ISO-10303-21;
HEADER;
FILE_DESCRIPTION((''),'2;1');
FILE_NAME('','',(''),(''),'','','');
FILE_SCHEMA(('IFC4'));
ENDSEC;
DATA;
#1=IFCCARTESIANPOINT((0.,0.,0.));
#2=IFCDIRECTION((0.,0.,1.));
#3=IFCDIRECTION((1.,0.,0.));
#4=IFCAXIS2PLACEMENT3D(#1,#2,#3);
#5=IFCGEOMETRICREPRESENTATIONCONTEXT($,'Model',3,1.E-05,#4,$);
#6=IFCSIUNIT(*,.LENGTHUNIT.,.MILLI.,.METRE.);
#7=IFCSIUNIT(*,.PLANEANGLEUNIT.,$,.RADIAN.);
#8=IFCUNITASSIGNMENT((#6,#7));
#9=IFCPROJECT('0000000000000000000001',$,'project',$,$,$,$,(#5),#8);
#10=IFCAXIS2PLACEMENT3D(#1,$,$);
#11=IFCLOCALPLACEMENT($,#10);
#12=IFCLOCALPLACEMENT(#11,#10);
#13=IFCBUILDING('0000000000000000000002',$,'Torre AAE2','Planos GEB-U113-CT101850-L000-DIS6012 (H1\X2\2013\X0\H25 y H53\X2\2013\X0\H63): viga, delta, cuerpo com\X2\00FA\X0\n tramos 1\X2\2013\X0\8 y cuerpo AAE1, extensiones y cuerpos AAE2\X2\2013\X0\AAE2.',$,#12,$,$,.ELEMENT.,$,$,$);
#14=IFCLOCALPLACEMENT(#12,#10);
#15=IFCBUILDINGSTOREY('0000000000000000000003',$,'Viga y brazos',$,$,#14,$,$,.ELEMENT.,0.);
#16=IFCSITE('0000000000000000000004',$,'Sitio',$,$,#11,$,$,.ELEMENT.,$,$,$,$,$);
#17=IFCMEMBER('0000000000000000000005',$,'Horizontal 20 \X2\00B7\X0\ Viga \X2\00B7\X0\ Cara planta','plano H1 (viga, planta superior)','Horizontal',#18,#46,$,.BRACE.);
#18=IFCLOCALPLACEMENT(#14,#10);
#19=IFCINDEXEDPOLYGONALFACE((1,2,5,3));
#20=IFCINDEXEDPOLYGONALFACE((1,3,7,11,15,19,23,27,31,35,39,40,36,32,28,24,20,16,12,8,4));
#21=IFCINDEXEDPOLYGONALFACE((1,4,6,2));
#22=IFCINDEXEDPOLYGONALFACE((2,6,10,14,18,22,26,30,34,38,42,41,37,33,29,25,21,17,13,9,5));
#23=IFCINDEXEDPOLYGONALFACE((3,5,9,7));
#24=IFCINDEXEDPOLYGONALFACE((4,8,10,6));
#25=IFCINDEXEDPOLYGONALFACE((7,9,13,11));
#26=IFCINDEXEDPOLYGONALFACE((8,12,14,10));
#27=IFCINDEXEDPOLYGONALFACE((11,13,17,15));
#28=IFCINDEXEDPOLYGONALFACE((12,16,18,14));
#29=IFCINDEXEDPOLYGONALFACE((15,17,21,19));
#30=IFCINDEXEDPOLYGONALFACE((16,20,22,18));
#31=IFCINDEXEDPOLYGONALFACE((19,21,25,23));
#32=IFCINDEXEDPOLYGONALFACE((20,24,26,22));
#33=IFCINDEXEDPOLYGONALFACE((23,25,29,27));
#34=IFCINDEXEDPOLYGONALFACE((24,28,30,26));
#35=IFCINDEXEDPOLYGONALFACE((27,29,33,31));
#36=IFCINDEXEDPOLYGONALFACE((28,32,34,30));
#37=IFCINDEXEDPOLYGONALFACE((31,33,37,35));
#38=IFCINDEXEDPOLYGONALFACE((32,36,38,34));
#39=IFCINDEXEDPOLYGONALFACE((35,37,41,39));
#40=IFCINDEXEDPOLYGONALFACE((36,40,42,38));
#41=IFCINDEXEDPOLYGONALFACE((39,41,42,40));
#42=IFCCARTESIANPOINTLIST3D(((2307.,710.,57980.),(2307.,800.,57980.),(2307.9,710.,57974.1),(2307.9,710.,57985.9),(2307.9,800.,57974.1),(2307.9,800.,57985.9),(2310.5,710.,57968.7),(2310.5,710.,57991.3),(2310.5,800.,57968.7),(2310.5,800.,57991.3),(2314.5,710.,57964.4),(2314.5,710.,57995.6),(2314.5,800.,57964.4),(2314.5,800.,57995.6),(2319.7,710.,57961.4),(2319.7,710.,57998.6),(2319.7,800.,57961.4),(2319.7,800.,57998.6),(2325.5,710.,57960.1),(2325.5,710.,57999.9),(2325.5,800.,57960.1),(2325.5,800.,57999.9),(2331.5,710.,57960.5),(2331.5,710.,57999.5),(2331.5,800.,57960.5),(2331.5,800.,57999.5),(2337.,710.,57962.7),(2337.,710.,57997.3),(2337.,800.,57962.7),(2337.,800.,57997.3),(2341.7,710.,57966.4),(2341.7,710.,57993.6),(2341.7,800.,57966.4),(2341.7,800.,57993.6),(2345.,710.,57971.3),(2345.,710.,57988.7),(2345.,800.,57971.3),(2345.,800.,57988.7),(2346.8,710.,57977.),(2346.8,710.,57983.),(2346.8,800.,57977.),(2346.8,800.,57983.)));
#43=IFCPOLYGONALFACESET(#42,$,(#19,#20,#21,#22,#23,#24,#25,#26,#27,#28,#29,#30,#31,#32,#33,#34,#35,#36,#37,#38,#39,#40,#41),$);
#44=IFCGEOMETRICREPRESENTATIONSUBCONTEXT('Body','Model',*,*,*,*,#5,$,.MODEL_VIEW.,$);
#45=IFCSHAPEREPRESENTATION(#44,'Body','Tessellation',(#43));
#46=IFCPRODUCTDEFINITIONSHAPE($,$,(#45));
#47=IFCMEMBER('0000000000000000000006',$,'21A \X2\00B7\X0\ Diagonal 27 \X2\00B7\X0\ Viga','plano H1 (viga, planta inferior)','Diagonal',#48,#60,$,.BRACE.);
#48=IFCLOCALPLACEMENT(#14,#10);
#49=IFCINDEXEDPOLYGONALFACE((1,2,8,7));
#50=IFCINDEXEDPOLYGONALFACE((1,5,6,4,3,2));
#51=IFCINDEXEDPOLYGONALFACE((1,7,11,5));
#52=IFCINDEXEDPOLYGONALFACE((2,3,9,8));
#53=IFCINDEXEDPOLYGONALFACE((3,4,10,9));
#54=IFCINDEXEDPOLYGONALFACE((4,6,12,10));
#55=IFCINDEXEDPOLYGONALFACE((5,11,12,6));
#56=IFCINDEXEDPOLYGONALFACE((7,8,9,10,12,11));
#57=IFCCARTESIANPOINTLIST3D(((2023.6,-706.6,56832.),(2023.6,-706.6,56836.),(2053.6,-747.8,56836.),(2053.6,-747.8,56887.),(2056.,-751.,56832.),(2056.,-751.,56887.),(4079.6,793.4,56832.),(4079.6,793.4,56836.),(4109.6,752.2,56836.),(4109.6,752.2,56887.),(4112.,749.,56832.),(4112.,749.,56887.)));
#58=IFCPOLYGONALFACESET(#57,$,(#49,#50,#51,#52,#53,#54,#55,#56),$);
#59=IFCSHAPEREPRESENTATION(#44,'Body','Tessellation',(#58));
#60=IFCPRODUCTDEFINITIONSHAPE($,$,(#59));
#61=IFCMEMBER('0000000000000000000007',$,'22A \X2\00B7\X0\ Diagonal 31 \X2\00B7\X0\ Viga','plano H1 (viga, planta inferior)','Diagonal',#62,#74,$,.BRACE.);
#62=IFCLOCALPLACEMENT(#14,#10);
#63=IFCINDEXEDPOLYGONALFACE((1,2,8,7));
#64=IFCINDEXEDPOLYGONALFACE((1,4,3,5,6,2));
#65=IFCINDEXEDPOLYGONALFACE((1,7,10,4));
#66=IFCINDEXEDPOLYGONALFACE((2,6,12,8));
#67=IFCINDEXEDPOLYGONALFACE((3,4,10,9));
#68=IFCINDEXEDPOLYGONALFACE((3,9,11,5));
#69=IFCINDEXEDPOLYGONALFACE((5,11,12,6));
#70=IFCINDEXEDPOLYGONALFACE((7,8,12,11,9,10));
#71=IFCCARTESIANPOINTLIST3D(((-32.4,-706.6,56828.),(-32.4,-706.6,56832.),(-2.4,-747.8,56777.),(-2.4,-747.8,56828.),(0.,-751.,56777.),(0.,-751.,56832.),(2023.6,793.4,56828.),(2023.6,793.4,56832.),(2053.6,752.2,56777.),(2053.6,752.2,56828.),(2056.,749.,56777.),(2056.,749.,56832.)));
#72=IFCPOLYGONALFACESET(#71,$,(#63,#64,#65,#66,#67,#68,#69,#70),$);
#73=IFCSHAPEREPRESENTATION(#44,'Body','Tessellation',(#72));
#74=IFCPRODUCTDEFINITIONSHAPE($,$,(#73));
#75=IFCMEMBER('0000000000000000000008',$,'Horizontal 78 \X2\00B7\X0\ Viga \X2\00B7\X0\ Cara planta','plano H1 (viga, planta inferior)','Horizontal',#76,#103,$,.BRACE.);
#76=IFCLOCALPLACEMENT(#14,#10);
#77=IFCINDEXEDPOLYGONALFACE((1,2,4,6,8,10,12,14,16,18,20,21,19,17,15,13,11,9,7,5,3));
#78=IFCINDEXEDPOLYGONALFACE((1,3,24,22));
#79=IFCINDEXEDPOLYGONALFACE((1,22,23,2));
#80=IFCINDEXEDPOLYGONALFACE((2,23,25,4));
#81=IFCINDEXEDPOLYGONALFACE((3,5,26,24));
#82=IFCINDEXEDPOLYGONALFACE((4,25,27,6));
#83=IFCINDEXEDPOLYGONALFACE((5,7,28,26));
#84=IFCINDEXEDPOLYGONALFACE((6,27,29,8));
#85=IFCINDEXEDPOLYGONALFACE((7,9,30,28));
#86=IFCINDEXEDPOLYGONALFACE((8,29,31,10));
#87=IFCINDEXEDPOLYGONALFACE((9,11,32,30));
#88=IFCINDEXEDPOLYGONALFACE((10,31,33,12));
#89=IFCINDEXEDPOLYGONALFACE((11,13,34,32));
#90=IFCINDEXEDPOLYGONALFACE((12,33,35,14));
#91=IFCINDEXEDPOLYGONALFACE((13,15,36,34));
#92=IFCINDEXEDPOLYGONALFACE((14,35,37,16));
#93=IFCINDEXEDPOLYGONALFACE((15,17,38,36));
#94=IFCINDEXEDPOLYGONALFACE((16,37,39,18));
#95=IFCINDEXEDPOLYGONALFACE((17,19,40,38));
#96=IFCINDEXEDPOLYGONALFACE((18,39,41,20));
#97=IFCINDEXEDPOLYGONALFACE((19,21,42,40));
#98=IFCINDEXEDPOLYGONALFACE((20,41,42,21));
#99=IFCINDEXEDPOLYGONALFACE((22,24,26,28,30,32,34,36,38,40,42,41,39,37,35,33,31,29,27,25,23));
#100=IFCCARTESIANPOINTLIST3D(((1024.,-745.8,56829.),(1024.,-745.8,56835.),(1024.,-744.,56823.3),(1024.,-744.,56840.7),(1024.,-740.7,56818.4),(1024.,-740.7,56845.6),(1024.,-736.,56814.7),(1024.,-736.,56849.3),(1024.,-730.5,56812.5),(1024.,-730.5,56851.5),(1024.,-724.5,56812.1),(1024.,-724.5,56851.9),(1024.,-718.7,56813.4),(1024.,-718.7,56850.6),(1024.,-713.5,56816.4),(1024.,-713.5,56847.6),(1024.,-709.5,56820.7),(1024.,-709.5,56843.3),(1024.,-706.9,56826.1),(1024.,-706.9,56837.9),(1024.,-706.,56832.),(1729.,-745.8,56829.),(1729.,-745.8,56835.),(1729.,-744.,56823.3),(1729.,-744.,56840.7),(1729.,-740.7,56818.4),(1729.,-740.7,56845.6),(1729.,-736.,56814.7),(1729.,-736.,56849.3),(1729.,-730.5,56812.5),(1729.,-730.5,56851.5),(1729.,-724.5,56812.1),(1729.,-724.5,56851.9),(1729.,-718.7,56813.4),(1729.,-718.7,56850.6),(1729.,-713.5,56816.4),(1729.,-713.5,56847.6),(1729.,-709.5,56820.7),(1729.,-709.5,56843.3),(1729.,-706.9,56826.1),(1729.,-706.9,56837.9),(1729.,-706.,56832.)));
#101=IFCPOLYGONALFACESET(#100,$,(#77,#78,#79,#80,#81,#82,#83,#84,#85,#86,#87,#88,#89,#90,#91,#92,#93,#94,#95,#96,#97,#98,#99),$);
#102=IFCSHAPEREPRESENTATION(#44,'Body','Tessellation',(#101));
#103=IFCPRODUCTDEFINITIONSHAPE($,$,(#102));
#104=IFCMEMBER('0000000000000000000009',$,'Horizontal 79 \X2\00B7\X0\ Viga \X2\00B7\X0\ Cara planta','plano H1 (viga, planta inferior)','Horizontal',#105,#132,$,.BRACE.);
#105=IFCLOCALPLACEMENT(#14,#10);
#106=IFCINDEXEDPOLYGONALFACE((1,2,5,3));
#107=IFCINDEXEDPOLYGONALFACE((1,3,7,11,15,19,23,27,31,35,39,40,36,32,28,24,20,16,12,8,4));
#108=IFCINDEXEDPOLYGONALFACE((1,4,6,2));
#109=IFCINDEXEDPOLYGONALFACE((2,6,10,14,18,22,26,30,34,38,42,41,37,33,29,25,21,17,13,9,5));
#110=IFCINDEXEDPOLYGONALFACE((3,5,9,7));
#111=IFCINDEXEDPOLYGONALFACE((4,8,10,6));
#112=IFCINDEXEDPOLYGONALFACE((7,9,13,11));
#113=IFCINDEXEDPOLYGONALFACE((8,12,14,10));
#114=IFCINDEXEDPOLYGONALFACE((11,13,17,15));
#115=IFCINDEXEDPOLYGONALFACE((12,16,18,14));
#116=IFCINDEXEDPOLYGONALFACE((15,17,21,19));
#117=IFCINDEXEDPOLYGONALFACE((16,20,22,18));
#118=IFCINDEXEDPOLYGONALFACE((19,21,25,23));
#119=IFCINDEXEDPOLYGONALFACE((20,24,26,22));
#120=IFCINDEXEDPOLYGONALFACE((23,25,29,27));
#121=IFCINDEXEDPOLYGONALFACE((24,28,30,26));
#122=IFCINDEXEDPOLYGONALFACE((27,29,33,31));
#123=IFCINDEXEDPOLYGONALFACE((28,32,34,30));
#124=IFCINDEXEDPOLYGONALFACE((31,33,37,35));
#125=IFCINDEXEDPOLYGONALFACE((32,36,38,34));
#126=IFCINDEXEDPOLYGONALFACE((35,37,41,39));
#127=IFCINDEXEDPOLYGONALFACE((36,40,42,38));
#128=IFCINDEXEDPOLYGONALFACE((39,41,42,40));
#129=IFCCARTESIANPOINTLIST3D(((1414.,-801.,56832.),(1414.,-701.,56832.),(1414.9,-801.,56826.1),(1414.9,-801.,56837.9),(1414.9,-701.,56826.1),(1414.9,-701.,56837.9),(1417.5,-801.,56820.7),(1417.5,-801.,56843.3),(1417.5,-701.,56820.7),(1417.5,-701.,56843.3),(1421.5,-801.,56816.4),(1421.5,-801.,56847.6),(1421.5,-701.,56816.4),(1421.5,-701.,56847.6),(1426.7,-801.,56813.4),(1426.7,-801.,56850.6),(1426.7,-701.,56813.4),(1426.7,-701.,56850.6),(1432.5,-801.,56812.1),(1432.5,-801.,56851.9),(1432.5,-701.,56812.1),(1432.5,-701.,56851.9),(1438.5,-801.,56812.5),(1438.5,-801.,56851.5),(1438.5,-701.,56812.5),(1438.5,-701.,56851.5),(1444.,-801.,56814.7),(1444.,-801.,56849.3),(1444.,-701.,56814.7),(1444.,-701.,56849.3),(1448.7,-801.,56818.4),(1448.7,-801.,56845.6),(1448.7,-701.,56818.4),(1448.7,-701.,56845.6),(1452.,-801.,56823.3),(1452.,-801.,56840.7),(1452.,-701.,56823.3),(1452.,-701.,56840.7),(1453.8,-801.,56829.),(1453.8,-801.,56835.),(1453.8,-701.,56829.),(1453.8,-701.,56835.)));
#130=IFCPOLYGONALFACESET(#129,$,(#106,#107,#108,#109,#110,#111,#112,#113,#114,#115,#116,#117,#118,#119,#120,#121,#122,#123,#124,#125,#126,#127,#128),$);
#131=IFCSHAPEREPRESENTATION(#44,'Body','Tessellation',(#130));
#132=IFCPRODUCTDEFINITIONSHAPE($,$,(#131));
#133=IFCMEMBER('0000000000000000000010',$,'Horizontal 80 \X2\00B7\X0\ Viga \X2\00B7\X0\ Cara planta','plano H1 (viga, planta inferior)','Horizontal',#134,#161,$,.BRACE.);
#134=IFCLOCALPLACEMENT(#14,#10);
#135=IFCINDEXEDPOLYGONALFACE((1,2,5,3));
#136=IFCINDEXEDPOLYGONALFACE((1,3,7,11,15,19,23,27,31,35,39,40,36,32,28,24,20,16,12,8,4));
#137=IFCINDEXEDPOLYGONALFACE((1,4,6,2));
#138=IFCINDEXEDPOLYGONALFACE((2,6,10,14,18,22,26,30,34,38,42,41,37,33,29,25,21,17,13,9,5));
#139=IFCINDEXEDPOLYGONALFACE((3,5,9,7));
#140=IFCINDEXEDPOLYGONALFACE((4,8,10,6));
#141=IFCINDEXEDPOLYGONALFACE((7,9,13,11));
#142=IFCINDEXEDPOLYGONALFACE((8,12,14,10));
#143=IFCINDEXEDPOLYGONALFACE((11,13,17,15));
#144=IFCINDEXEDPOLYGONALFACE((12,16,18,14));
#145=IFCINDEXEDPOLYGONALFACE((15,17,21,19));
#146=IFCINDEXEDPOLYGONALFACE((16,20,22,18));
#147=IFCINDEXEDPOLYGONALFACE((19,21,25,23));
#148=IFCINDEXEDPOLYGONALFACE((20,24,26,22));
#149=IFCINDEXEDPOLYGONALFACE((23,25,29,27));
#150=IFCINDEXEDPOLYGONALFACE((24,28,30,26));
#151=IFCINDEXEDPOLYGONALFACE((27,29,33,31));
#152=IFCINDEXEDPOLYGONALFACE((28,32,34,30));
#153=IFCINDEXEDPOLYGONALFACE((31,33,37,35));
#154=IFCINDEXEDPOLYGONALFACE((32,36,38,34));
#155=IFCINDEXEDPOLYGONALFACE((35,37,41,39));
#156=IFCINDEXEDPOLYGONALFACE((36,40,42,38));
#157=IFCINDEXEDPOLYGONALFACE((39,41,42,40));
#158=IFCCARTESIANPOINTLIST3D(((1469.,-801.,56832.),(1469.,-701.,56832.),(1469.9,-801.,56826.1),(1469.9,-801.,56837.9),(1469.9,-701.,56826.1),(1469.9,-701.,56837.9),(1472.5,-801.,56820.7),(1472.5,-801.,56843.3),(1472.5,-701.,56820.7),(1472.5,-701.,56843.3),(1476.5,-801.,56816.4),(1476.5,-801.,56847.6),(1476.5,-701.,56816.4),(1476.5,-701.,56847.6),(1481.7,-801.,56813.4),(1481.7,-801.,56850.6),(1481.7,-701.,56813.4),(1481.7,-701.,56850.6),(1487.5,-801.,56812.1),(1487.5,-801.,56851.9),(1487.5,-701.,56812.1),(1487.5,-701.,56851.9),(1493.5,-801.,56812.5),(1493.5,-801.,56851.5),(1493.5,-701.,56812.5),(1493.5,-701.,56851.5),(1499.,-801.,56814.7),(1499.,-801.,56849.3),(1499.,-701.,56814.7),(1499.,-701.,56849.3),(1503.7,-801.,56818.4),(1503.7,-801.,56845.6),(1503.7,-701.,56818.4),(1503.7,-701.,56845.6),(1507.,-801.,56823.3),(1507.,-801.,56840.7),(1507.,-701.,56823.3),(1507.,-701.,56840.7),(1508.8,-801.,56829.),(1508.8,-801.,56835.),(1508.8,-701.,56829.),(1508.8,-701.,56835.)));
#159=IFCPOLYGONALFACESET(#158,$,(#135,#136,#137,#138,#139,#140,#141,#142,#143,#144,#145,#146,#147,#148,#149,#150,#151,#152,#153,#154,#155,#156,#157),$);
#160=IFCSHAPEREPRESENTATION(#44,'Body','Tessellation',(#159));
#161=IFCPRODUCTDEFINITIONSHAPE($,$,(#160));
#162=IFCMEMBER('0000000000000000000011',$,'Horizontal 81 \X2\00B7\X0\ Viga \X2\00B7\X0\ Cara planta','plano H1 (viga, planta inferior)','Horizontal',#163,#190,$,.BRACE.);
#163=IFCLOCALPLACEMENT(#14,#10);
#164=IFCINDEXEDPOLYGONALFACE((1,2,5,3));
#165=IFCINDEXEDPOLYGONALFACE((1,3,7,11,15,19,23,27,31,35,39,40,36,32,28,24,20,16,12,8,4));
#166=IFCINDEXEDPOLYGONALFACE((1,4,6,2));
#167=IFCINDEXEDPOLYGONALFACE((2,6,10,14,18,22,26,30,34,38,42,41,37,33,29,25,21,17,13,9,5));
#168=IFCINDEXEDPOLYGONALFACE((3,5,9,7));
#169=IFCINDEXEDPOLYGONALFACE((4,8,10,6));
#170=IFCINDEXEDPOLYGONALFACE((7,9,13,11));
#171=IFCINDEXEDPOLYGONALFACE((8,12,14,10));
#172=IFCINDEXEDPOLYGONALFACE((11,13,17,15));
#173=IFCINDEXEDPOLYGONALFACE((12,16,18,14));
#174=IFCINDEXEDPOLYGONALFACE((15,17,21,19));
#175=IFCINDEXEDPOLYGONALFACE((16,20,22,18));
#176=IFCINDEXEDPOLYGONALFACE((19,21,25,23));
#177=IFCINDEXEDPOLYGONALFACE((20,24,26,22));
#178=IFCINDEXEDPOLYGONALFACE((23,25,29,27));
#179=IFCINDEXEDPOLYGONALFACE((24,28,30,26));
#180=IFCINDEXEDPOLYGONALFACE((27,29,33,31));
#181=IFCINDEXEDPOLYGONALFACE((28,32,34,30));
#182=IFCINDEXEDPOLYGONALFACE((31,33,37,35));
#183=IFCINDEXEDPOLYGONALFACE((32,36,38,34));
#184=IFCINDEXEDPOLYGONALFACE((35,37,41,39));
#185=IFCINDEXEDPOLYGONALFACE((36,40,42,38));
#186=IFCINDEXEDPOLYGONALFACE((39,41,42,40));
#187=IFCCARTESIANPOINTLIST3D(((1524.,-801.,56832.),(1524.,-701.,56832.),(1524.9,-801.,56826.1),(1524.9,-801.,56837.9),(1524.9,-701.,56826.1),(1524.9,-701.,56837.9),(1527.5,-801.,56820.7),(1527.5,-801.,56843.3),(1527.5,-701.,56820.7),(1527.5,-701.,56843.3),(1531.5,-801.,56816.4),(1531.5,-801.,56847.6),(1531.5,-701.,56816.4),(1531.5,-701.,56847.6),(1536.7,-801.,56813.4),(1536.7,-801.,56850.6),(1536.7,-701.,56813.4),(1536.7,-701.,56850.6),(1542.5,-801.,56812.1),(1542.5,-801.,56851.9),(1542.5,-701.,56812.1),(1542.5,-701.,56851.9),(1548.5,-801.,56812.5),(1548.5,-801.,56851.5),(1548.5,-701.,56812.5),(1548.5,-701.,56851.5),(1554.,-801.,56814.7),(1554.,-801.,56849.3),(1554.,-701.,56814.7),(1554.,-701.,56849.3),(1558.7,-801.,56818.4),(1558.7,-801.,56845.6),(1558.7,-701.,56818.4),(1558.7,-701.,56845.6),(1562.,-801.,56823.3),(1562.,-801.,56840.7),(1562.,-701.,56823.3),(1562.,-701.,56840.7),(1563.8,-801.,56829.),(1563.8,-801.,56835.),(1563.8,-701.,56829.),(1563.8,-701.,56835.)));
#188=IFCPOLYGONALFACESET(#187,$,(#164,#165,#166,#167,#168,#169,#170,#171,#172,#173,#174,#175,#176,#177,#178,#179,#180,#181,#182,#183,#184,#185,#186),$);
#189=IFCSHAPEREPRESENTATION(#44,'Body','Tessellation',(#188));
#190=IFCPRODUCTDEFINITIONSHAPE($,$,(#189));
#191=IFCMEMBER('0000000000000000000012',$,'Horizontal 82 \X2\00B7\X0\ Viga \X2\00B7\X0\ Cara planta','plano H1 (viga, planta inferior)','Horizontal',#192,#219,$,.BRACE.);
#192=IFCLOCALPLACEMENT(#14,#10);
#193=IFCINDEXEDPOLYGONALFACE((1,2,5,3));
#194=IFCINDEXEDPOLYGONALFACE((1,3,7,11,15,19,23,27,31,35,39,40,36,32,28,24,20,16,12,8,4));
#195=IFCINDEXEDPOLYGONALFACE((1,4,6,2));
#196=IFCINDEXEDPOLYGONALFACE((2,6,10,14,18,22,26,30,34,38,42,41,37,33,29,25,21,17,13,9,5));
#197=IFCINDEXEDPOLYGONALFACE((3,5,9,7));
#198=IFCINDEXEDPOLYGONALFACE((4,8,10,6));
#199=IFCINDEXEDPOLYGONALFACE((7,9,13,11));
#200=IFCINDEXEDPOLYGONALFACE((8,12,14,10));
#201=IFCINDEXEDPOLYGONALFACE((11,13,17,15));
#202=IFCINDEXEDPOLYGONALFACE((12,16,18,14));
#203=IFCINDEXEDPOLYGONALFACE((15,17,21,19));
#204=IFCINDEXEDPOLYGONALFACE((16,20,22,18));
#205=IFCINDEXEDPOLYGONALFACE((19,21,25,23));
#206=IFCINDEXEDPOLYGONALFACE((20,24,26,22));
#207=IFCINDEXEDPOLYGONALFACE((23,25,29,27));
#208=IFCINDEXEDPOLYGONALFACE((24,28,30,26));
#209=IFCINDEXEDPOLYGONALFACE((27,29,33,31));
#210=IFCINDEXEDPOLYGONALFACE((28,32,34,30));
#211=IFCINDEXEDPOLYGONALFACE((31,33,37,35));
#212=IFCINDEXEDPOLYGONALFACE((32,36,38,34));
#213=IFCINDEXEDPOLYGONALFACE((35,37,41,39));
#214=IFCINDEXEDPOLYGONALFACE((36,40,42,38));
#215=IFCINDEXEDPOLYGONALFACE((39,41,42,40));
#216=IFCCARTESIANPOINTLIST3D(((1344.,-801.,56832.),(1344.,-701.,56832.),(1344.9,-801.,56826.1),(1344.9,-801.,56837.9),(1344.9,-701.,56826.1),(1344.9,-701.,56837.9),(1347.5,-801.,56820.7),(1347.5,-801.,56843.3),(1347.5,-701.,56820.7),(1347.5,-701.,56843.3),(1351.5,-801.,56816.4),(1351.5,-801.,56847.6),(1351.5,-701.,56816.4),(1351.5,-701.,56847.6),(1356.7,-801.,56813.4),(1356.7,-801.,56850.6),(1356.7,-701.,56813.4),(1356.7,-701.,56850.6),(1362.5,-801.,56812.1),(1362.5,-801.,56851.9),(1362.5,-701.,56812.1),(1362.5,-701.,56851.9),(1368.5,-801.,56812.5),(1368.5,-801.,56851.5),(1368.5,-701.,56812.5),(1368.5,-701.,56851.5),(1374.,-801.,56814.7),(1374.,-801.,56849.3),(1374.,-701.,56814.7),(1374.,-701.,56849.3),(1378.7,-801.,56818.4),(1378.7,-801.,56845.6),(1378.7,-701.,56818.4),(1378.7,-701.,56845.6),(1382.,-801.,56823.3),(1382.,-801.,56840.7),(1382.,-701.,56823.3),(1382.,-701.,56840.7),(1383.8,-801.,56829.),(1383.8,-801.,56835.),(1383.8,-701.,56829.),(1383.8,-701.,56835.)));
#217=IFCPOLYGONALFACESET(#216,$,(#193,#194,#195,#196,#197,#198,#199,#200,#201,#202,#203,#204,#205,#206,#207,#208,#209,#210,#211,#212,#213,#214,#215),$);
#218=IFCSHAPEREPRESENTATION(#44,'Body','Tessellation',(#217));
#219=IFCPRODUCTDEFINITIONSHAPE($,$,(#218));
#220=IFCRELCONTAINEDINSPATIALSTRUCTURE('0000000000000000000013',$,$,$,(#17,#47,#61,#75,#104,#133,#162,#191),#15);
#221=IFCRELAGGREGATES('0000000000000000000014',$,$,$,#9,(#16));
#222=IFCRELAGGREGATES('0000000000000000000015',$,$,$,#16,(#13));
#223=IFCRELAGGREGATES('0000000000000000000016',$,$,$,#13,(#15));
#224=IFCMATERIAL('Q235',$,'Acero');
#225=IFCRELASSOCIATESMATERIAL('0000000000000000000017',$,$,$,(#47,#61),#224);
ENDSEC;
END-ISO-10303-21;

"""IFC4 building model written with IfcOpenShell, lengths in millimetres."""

from ifc_helpers import new_model, si_unit, frame, frame_2d, origin, origin_with_axes, place, context, subcontext, project, spatial, circle, l_section, extrude, material, element, save


model = new_model("IFC4")

# Units and contexts
model_context = context("Model", 3, precision=1e-05, world=origin_with_axes())
body_context = subcontext(model_context, "Body", "Model", "MODEL_VIEW")
ifc_project = project(units=[si_unit("LENGTHUNIT", "METRE", prefix="MILLI"), si_unit("PLANEANGLEUNIT", "RADIAN")], contexts=[model_context])

# Site, building, storey
site_placement = place(None, origin())
site = spatial("IfcSite", under=ifc_project, at=site_placement, Name="Sitio", CompositionType="ELEMENT")
building_placement = place(site_placement, origin())
building = spatial("IfcBuilding", under=site, at=building_placement, Name="Torre AAE2", Description="Planos GEB-U113-CT101850-L000-DIS6012 (H1–H25 y H53–H63): viga, delta, cuerpo común tramos 1–8 y cuerpo AAE1, extensiones y cuerpos AAE2–AAE2.", CompositionType="ELEMENT")
storey_placement = place(building_placement, origin())
storey = spatial("IfcBuildingStorey", under=building, at=storey_placement, Name="Viga y brazos", CompositionType="ELEMENT", Elevation=0.0)

# Members
ifc_material = material(Name="Q235", Category="Acero")
for number, where, z_axis, x_axis, name in (
    (1, (2327.0, 710.0, 57980.0), (0.0, 1.0, 0.0), (-1.0, 0.0, 0.0), "Horizontal 20 · Viga · Cara planta"),
):
    element("IfcMember", number, at=place(storey_placement, frame(where, z_axis=z_axis, x_axis=x_axis)), inside=storey, Name=name, Description="plano H1 (viga, planta superior)", ObjectType="Horizontal", PredefinedType="BRACE", context=body_context, shape_type="SweptSolid", body=[
        extrude(circle(Radius=20.0), None, (0.0, 0.0, 1.0), 90.0),
    ])
for number, where, z_axis, x_axis, name in (
    (2, (2056.0, -751.0, 56832.0), (0.807852, 0.589386, 0.0), (-0.589386, 0.807852, 0.0), "21A · Diagonal 27 · Viga"),
    (3, (2056.0, 749.0, 56832.0), (-0.807852, -0.589386, 0.0), (-0.589386, 0.807852, 0.0), "22A · Diagonal 31 · Viga"),
):
    element("IfcMember", number, at=place(storey_placement, frame(where, z_axis=z_axis, x_axis=x_axis)), inside=storey, material=ifc_material, Name=name, Description="plano H1 (viga, planta inferior)", ObjectType="Diagonal", PredefinedType="BRACE", context=body_context, shape_type="SweptSolid", body=[
        extrude(l_section(Depth=55.0, Width=55.0, Thickness=4.0, at=frame_2d((27.5, 27.5))), None, (0.0, 0.0, 1.0), 2545.0),
    ])
member_placement = place(storey_placement, frame((1729.0, -726.0, 56832.0), z_axis=(-1.0, 0.0, 0.0), x_axis=(0.0, 1.0, 0.0)))
element("IfcMember", 4, at=member_placement, inside=storey, Name="Horizontal 78 · Viga · Cara planta", Description="plano H1 (viga, planta inferior)", ObjectType="Horizontal", PredefinedType="BRACE", context=body_context, shape_type="SweptSolid", body=[
    extrude(circle(Radius=20.0), None, (0.0, 0.0, 1.0), 705.0),
])
for number, where, z_axis, x_axis, name in (
    (5, (1434.0, -701.0, 56832.0), (0.0, -1.0, 0.0), (-1.0, 0.0, 0.0), "Horizontal 79 · Viga · Cara planta"),
    (6, (1489.0, -701.0, 56832.0), (0.0, -1.0, 0.0), (-1.0, 0.0, 0.0), "Horizontal 80 · Viga · Cara planta"),
    (7, (1544.0, -701.0, 56832.0), (0.0, -1.0, 0.0), (-1.0, 0.0, 0.0), "Horizontal 81 · Viga · Cara planta"),
    (8, (1364.0, -701.0, 56832.0), (0.0, -1.0, 0.0), (-1.0, 0.0, 0.0), "Horizontal 82 · Viga · Cara planta"),
):
    element("IfcMember", number, at=place(storey_placement, frame(where, z_axis=z_axis, x_axis=x_axis)), inside=storey, Name=name, Description="plano H1 (viga, planta inferior)", ObjectType="Horizontal", PredefinedType="BRACE", context=body_context, shape_type="SweptSolid", body=[
        extrude(circle(Radius=20.0), None, (0.0, 0.0, 1.0), 100.0),
    ])

save(model, "model.ifc")
